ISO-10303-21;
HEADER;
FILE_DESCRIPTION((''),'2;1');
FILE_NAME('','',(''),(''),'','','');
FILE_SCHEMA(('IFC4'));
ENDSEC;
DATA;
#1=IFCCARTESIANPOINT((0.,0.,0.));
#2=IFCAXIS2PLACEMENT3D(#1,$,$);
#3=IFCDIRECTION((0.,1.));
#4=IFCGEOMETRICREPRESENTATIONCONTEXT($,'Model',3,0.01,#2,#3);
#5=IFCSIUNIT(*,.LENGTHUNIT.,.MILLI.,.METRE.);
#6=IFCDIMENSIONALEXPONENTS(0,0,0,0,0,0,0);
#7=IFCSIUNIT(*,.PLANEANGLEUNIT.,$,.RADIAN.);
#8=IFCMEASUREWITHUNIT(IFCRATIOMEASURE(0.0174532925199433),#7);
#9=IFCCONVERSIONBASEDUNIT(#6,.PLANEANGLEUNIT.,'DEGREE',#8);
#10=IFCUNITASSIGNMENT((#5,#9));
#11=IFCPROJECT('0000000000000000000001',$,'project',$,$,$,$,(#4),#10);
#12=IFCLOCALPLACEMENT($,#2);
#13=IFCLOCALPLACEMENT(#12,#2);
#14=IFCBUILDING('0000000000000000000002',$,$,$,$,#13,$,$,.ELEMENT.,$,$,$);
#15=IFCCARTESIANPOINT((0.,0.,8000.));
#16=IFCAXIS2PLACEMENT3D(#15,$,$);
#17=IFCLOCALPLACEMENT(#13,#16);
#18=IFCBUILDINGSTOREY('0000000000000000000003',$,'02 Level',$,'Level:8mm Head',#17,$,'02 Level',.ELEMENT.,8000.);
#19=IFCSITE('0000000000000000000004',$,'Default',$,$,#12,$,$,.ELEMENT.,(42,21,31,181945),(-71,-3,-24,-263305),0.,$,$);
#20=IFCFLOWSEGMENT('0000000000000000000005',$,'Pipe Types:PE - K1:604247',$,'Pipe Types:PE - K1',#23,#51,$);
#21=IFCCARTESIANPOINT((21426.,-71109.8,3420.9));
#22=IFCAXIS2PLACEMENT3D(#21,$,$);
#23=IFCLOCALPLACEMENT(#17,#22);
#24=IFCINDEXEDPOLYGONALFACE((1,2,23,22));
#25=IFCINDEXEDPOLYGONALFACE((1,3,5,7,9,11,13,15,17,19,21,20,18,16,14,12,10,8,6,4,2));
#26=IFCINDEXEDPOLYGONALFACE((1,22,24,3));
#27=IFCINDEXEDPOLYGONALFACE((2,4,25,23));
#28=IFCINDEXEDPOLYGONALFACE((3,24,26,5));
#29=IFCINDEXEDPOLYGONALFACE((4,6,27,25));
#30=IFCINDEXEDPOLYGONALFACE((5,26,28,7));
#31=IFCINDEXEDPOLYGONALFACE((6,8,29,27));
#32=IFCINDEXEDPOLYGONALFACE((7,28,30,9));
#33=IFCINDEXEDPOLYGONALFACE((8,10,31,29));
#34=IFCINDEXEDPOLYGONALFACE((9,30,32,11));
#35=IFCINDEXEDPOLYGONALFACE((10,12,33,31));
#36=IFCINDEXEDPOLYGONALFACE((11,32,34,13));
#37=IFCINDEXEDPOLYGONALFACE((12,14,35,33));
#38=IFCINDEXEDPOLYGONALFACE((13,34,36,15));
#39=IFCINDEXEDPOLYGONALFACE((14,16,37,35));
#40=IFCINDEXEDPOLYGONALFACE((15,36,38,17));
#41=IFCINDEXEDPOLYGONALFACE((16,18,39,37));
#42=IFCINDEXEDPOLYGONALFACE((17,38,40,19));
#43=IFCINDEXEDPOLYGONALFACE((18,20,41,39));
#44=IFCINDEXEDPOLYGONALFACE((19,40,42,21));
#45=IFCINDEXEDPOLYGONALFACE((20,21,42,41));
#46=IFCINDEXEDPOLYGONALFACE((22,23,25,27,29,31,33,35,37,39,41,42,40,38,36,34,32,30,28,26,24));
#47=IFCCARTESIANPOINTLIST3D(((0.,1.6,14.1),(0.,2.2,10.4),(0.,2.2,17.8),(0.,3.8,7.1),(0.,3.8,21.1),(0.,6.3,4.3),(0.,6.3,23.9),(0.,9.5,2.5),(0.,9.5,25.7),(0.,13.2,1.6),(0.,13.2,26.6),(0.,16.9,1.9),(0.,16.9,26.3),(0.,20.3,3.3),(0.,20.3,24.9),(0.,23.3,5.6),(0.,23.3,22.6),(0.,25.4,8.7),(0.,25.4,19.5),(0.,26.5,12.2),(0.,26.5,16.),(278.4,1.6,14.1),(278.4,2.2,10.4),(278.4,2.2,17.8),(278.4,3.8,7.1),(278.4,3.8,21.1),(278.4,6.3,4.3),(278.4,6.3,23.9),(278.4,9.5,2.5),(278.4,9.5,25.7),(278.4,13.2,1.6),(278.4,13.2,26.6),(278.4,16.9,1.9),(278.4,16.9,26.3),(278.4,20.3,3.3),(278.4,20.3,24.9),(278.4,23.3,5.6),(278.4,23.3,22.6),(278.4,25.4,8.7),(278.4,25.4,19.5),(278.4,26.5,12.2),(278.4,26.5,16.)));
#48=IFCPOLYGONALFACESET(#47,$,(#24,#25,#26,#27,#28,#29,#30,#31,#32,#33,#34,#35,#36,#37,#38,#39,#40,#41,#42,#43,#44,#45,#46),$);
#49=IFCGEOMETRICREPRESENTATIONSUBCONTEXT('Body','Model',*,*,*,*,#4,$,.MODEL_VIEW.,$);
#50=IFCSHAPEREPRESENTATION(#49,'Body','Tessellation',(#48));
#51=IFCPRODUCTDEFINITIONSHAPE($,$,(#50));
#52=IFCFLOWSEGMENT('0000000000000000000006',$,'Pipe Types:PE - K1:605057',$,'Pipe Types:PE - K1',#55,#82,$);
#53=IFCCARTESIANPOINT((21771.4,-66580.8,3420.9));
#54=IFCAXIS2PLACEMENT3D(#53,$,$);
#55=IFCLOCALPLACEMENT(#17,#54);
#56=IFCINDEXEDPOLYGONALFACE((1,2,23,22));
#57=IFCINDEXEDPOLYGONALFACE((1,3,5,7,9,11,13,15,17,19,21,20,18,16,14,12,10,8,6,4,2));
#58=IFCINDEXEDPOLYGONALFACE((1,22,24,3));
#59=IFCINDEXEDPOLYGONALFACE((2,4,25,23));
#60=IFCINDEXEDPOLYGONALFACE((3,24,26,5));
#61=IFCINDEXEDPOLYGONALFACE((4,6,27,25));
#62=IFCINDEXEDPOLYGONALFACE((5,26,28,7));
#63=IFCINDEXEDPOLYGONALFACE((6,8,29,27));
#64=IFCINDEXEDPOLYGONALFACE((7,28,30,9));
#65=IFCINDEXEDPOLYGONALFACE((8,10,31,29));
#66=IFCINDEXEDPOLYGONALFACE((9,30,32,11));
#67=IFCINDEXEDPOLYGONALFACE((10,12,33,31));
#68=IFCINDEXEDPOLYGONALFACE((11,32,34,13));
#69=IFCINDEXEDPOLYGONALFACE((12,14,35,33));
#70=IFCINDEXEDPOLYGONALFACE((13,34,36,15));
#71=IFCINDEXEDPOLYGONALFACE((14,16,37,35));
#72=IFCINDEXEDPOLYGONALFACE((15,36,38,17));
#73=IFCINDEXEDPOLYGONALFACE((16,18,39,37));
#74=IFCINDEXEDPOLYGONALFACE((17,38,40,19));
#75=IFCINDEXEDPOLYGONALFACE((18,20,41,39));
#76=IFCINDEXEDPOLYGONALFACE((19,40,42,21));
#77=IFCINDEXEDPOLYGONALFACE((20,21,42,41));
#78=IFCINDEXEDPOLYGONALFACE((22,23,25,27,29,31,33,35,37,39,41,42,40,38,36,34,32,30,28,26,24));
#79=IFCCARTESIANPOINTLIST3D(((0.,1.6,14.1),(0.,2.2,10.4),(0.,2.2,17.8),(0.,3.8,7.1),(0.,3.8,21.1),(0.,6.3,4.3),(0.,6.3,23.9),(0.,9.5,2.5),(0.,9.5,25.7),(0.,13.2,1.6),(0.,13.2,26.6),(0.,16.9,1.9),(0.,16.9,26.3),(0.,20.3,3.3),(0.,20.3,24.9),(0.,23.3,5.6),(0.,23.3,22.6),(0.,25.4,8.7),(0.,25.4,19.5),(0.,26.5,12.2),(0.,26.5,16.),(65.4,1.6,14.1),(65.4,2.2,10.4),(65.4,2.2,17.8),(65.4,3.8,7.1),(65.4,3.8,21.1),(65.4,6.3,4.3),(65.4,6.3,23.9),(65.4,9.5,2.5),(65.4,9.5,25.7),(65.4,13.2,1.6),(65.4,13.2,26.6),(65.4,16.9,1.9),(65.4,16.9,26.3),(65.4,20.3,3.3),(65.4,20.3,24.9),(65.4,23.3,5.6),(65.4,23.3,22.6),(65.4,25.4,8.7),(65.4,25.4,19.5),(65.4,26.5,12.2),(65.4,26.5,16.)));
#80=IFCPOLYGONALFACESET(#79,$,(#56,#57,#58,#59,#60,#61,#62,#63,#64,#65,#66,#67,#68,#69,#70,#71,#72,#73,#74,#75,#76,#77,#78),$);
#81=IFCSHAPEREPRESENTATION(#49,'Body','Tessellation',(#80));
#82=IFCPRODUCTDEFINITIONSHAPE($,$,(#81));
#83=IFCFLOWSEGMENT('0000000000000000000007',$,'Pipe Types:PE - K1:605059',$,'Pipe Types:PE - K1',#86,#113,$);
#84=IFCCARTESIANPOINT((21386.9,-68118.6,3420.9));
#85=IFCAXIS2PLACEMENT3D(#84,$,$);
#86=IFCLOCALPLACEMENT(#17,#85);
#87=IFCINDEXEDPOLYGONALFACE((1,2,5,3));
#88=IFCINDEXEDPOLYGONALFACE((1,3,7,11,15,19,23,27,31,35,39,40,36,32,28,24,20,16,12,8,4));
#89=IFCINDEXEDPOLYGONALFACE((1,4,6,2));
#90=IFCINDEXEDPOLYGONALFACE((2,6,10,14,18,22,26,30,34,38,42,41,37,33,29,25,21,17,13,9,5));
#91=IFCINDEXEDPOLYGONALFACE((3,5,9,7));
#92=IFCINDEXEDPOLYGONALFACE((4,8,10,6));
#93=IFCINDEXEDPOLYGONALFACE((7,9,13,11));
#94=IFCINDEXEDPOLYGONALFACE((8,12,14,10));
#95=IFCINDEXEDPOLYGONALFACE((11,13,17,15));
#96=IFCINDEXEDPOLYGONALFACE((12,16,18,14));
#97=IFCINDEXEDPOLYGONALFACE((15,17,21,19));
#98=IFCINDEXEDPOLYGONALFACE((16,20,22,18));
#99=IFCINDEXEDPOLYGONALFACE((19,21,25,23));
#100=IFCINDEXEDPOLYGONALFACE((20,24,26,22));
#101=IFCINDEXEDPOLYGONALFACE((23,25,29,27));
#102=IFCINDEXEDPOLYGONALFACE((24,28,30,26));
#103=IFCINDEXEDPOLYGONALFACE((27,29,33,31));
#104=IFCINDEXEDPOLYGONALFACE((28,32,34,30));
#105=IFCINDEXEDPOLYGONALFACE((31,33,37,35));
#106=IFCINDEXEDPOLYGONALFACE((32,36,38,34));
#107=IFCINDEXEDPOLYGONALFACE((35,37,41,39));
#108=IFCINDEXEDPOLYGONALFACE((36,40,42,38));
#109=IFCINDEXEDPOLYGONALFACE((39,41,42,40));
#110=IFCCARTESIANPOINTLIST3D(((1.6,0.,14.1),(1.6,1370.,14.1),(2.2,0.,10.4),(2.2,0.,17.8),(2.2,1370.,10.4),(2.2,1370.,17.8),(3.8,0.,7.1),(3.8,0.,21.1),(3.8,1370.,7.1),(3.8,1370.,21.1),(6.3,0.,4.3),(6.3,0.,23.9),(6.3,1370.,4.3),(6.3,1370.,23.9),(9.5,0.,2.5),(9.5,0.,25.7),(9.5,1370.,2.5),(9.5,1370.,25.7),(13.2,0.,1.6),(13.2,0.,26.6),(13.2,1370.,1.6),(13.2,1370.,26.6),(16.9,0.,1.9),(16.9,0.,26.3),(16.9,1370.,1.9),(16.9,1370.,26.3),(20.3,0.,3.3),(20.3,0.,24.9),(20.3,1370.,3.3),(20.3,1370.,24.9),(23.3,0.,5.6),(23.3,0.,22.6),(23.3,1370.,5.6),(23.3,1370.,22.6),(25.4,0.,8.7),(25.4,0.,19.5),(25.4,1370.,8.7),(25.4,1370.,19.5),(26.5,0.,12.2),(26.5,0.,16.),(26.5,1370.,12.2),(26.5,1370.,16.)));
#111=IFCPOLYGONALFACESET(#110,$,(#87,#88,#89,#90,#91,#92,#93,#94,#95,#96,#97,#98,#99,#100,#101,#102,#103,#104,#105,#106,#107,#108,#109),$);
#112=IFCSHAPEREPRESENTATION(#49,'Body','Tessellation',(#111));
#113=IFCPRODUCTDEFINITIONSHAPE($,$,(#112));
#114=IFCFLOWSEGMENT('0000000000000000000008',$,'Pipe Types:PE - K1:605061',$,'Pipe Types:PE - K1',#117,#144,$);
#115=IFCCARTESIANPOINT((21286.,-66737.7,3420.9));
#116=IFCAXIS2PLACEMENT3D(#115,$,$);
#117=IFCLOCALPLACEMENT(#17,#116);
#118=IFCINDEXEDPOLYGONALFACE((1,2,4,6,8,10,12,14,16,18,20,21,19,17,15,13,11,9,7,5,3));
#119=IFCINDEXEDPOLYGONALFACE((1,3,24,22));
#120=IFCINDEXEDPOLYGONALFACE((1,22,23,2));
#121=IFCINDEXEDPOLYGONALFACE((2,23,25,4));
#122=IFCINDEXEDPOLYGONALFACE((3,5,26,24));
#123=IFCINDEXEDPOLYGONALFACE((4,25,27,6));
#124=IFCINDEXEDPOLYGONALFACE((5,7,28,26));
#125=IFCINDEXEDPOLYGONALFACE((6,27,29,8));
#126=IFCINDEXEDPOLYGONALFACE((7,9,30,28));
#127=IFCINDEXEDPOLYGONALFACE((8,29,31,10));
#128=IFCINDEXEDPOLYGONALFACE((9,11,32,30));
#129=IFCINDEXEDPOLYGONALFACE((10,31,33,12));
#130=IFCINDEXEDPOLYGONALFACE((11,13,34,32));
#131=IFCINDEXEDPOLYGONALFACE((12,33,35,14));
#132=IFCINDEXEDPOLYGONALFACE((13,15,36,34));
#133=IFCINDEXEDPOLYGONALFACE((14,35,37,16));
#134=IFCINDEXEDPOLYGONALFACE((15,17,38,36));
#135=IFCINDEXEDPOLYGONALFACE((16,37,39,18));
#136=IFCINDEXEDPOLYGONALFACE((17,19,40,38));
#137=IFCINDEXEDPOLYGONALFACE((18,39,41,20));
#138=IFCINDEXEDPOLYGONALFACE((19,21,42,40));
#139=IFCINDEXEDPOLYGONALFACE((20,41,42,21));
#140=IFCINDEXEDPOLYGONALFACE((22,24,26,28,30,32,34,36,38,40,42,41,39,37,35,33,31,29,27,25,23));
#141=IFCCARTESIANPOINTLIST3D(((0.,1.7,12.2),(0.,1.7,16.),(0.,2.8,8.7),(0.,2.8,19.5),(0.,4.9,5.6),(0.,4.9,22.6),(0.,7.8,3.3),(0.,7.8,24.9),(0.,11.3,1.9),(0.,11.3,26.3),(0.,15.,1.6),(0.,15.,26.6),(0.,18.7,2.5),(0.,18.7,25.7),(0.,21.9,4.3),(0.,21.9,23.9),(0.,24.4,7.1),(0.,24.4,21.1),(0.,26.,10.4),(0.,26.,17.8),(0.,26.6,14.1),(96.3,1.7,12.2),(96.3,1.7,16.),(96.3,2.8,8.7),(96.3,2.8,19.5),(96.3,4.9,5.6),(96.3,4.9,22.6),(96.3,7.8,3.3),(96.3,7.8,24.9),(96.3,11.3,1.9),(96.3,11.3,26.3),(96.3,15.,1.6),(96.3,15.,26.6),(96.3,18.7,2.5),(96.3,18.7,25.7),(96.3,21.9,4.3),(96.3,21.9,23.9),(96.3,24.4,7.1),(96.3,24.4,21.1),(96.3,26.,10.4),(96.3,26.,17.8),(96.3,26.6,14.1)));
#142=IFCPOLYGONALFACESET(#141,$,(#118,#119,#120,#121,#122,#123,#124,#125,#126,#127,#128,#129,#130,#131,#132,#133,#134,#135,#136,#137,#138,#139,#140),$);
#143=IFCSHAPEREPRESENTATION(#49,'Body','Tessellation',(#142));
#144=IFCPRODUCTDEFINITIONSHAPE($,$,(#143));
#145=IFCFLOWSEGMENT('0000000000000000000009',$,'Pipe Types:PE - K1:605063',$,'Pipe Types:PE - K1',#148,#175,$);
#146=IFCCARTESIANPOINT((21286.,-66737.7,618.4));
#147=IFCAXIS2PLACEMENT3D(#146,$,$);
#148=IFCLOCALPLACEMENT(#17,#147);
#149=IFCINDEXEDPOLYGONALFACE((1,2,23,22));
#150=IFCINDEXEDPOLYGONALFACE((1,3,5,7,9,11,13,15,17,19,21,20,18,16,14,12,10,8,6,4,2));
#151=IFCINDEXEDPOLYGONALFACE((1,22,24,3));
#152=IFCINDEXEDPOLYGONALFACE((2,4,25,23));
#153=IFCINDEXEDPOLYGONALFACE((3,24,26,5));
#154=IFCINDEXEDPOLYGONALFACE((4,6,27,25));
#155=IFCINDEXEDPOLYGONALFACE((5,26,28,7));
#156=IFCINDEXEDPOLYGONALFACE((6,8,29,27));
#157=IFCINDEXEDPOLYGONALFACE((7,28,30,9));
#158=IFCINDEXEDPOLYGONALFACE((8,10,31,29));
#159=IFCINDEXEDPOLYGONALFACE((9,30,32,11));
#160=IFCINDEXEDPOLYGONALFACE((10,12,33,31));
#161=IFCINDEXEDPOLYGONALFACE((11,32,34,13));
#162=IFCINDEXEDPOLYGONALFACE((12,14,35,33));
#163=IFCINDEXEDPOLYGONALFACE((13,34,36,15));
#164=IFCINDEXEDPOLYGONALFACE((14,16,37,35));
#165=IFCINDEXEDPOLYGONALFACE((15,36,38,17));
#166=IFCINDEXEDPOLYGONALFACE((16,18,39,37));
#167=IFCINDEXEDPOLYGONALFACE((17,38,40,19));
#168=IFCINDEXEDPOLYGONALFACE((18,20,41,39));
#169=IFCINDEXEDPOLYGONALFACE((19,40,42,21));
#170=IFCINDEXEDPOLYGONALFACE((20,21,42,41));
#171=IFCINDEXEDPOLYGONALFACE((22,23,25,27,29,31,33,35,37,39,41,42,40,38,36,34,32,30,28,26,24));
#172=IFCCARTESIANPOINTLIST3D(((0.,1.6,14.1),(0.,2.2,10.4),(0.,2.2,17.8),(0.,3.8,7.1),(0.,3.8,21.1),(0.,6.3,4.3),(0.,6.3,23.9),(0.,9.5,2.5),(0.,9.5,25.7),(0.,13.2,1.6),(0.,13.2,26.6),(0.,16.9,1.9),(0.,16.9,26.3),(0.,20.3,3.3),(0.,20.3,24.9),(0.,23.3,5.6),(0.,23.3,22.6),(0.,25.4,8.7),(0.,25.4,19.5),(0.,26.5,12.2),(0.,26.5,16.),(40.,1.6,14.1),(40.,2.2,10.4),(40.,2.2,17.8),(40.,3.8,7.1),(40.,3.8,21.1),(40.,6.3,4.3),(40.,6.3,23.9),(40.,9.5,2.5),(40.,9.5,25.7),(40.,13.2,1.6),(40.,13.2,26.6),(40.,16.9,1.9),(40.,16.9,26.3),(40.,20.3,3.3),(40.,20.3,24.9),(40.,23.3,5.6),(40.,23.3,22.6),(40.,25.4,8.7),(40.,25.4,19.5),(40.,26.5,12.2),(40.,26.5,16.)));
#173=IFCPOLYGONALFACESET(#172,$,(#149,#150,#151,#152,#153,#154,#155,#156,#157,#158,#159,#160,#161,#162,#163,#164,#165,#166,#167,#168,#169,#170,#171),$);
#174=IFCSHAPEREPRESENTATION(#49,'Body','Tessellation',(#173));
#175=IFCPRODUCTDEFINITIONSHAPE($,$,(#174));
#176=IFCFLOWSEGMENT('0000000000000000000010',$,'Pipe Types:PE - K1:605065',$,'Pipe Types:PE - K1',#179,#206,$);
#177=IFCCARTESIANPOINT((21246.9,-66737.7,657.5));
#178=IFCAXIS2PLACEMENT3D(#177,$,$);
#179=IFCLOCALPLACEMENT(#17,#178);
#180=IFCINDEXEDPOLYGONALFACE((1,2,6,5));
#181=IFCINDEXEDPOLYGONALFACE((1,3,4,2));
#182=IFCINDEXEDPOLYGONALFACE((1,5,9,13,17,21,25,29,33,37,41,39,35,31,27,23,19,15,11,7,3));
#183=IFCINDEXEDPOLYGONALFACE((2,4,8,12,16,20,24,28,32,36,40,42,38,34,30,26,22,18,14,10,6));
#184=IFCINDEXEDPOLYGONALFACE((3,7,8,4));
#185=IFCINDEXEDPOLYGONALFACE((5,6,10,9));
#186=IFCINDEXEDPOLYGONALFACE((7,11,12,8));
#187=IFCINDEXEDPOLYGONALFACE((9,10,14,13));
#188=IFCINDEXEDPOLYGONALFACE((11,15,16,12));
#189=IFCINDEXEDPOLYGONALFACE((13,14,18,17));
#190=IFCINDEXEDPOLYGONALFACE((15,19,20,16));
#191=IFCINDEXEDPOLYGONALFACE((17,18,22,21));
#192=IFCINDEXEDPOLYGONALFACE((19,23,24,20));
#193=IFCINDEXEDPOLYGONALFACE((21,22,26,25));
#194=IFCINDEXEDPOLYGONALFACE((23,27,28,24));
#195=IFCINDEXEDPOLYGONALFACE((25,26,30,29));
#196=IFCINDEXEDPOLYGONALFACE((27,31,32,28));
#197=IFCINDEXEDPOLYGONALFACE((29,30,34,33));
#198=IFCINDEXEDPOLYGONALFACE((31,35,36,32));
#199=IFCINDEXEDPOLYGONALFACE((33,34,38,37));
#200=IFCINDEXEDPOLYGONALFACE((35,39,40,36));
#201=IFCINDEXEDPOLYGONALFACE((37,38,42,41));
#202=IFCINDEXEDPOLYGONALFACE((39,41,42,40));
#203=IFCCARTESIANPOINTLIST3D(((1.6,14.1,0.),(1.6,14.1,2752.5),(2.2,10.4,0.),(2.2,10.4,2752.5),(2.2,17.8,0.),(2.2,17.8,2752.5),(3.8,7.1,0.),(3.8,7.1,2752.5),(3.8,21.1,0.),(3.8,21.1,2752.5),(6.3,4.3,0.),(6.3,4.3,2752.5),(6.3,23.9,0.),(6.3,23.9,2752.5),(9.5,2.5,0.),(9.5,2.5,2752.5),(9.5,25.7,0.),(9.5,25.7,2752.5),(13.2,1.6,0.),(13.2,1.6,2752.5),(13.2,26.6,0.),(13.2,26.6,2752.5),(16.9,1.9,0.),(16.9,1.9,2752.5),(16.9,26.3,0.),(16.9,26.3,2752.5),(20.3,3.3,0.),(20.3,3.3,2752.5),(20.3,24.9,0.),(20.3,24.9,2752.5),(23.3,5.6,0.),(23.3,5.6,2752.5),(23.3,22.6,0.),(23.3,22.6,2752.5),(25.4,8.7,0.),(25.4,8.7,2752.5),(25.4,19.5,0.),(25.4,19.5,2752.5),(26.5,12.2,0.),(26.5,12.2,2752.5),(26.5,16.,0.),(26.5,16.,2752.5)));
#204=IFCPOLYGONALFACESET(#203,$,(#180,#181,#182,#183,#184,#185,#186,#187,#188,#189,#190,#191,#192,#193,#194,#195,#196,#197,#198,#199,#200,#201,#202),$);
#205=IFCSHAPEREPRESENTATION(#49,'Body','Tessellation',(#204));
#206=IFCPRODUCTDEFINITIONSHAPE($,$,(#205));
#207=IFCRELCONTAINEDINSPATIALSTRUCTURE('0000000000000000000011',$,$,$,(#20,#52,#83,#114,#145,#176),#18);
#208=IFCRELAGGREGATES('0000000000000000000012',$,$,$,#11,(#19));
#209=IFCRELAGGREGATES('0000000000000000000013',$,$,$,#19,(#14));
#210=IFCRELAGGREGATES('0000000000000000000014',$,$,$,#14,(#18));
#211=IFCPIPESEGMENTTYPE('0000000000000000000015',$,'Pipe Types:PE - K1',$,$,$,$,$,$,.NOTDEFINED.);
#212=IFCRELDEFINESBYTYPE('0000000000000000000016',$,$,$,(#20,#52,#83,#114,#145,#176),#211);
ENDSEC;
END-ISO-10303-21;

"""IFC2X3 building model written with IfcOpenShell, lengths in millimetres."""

from ifc_helpers import new_model, entity, si_unit, converted_unit, direction, frame, frame_2d, origin, origin_2d_with_axis, place, context, subcontext, project, spatial, circle, extrude, type_object, element, save


model = new_model("IFC2X3")

# Units and contexts
model_context = context("Model", 3, precision=0.01, world=origin(), true_north=direction((0.0, 1.0)))
body_context = subcontext(model_context, "Body", "Model", "MODEL_VIEW")
ifc_project = project(units=[si_unit("LENGTHUNIT", "METRE", prefix="MILLI"), converted_unit("PLANEANGLEUNIT", "DEGREE", entity("IfcRatioMeasure", 0.0174532925199433), si_unit("PLANEANGLEUNIT", "RADIAN"), dimensions=[0, 0, 0, 0, 0, 0, 0])], contexts=[model_context])

# Site, building, storey
site_placement = place(None, origin())
site = spatial("IfcSite", under=ifc_project, at=site_placement, Name="Default", CompositionType="ELEMENT", RefLatitude=(42, 21, 31, 181945), RefLongitude=(-71, -3, -24, -263305), RefElevation=0.0)
building_placement = place(site_placement, origin())
building = spatial("IfcBuilding", under=site, at=building_placement, CompositionType="ELEMENT")
storey_placement = place(building_placement, frame((0.0, 0.0, 8000.0)))
storey = spatial("IfcBuildingStorey", under=building, at=storey_placement, Name="02 Level", ObjectType="Level:8mm Head", LongName="02 Level", CompositionType="ELEMENT", Elevation=8000.0)

# Flow segments
pipe_segment_type = type_object("IfcPipeSegmentType", Name="Pipe Types:PE - K1", PredefinedType="NOTDEFINED")
flow_segment_1_placement = place(storey_placement, frame((21426.0, -71109.8, 3420.9)))
element("IfcFlowSegment", 1, at=flow_segment_1_placement, inside=storey, type_object=pipe_segment_type, Name="Pipe Types:PE - K1:604247", ObjectType="Pipe Types:PE - K1", context=body_context, shape_type="SweptSolid", body=[
    extrude(circle(Radius=12.5, at=origin_2d_with_axis()), frame((0.0, 14.1, 14.1), z_axis=(1.0, 0.0, 0.0), x_axis=(0.0, -1.0, 0.0)), (0.0, 0.0, 1.0), 278.4),
])
flow_segment_2_placement = place(storey_placement, frame((21771.4, -66580.8, 3420.9)))
element("IfcFlowSegment", 2, at=flow_segment_2_placement, inside=storey, type_object=pipe_segment_type, Name="Pipe Types:PE - K1:605057", ObjectType="Pipe Types:PE - K1", context=body_context, shape_type="SweptSolid", body=[
    extrude(circle(Radius=12.5, at=origin_2d_with_axis()), frame((0.0, 14.1, 14.1), z_axis=(1.0, 0.0, 0.0), x_axis=(0.0, -1.0, 0.0)), (0.0, 0.0, 1.0), 65.4),
])
flow_segment_3_placement = place(storey_placement, frame((21386.9, -68118.6, 3420.9)))
element("IfcFlowSegment", 3, at=flow_segment_3_placement, inside=storey, type_object=pipe_segment_type, Name="Pipe Types:PE - K1:605059", ObjectType="Pipe Types:PE - K1", context=body_context, shape_type="SweptSolid", body=[
    extrude(circle(Radius=12.5, at=frame_2d((0.0, 0.0), x_axis=(1.0, 0.0))), frame((14.1, 0.0, 14.1), z_axis=(0.0, 1.0, 0.0), x_axis=(-1.0, 0.0, 0.0)), (0.0, 0.0, 1.0), 1370.0),
])
flow_segment_4_placement = place(storey_placement, frame((21286.0, -66737.7, 3420.9)))
element("IfcFlowSegment", 4, at=flow_segment_4_placement, inside=storey, type_object=pipe_segment_type, Name="Pipe Types:PE - K1:605061", ObjectType="Pipe Types:PE - K1", context=body_context, shape_type="SweptSolid", body=[
    extrude(circle(Radius=12.5, at=origin_2d_with_axis()), frame((0.0, 14.1, 14.1), z_axis=(1.0, 0.0, 0.0), x_axis=(0.0, 1.0, 0.0)), (0.0, 0.0, 1.0), 96.3),
])
flow_segment_5_placement = place(storey_placement, frame((21286.0, -66737.7, 618.4)))
element("IfcFlowSegment", 5, at=flow_segment_5_placement, inside=storey, type_object=pipe_segment_type, Name="Pipe Types:PE - K1:605063", ObjectType="Pipe Types:PE - K1", context=body_context, shape_type="SweptSolid", body=[
    extrude(circle(Radius=12.5, at=frame_2d((0.0, 0.0), x_axis=(1.0, 0.0))), frame((0.0, 14.1, 14.1), z_axis=(1.0, 0.0, 0.0), x_axis=(0.0, -1.0, 0.0)), (0.0, 0.0, 1.0), 40.0),
])
flow_segment_6_placement = place(storey_placement, frame((21246.9, -66737.7, 657.5)))
element("IfcFlowSegment", 6, at=flow_segment_6_placement, inside=storey, type_object=pipe_segment_type, Name="Pipe Types:PE - K1:605065", ObjectType="Pipe Types:PE - K1", context=body_context, shape_type="SweptSolid", body=[
    extrude(circle(Radius=12.5, at=frame_2d((0.0, 0.0), x_axis=(1.0, 0.0))), frame((14.1, 14.1, 0.0), z_axis=(0.0, 0.0, 1.0), x_axis=(-1.0, 0.0, 0.0)), (0.0, 0.0, 1.0), 2752.5),
])

save(model, "model.ifc")
